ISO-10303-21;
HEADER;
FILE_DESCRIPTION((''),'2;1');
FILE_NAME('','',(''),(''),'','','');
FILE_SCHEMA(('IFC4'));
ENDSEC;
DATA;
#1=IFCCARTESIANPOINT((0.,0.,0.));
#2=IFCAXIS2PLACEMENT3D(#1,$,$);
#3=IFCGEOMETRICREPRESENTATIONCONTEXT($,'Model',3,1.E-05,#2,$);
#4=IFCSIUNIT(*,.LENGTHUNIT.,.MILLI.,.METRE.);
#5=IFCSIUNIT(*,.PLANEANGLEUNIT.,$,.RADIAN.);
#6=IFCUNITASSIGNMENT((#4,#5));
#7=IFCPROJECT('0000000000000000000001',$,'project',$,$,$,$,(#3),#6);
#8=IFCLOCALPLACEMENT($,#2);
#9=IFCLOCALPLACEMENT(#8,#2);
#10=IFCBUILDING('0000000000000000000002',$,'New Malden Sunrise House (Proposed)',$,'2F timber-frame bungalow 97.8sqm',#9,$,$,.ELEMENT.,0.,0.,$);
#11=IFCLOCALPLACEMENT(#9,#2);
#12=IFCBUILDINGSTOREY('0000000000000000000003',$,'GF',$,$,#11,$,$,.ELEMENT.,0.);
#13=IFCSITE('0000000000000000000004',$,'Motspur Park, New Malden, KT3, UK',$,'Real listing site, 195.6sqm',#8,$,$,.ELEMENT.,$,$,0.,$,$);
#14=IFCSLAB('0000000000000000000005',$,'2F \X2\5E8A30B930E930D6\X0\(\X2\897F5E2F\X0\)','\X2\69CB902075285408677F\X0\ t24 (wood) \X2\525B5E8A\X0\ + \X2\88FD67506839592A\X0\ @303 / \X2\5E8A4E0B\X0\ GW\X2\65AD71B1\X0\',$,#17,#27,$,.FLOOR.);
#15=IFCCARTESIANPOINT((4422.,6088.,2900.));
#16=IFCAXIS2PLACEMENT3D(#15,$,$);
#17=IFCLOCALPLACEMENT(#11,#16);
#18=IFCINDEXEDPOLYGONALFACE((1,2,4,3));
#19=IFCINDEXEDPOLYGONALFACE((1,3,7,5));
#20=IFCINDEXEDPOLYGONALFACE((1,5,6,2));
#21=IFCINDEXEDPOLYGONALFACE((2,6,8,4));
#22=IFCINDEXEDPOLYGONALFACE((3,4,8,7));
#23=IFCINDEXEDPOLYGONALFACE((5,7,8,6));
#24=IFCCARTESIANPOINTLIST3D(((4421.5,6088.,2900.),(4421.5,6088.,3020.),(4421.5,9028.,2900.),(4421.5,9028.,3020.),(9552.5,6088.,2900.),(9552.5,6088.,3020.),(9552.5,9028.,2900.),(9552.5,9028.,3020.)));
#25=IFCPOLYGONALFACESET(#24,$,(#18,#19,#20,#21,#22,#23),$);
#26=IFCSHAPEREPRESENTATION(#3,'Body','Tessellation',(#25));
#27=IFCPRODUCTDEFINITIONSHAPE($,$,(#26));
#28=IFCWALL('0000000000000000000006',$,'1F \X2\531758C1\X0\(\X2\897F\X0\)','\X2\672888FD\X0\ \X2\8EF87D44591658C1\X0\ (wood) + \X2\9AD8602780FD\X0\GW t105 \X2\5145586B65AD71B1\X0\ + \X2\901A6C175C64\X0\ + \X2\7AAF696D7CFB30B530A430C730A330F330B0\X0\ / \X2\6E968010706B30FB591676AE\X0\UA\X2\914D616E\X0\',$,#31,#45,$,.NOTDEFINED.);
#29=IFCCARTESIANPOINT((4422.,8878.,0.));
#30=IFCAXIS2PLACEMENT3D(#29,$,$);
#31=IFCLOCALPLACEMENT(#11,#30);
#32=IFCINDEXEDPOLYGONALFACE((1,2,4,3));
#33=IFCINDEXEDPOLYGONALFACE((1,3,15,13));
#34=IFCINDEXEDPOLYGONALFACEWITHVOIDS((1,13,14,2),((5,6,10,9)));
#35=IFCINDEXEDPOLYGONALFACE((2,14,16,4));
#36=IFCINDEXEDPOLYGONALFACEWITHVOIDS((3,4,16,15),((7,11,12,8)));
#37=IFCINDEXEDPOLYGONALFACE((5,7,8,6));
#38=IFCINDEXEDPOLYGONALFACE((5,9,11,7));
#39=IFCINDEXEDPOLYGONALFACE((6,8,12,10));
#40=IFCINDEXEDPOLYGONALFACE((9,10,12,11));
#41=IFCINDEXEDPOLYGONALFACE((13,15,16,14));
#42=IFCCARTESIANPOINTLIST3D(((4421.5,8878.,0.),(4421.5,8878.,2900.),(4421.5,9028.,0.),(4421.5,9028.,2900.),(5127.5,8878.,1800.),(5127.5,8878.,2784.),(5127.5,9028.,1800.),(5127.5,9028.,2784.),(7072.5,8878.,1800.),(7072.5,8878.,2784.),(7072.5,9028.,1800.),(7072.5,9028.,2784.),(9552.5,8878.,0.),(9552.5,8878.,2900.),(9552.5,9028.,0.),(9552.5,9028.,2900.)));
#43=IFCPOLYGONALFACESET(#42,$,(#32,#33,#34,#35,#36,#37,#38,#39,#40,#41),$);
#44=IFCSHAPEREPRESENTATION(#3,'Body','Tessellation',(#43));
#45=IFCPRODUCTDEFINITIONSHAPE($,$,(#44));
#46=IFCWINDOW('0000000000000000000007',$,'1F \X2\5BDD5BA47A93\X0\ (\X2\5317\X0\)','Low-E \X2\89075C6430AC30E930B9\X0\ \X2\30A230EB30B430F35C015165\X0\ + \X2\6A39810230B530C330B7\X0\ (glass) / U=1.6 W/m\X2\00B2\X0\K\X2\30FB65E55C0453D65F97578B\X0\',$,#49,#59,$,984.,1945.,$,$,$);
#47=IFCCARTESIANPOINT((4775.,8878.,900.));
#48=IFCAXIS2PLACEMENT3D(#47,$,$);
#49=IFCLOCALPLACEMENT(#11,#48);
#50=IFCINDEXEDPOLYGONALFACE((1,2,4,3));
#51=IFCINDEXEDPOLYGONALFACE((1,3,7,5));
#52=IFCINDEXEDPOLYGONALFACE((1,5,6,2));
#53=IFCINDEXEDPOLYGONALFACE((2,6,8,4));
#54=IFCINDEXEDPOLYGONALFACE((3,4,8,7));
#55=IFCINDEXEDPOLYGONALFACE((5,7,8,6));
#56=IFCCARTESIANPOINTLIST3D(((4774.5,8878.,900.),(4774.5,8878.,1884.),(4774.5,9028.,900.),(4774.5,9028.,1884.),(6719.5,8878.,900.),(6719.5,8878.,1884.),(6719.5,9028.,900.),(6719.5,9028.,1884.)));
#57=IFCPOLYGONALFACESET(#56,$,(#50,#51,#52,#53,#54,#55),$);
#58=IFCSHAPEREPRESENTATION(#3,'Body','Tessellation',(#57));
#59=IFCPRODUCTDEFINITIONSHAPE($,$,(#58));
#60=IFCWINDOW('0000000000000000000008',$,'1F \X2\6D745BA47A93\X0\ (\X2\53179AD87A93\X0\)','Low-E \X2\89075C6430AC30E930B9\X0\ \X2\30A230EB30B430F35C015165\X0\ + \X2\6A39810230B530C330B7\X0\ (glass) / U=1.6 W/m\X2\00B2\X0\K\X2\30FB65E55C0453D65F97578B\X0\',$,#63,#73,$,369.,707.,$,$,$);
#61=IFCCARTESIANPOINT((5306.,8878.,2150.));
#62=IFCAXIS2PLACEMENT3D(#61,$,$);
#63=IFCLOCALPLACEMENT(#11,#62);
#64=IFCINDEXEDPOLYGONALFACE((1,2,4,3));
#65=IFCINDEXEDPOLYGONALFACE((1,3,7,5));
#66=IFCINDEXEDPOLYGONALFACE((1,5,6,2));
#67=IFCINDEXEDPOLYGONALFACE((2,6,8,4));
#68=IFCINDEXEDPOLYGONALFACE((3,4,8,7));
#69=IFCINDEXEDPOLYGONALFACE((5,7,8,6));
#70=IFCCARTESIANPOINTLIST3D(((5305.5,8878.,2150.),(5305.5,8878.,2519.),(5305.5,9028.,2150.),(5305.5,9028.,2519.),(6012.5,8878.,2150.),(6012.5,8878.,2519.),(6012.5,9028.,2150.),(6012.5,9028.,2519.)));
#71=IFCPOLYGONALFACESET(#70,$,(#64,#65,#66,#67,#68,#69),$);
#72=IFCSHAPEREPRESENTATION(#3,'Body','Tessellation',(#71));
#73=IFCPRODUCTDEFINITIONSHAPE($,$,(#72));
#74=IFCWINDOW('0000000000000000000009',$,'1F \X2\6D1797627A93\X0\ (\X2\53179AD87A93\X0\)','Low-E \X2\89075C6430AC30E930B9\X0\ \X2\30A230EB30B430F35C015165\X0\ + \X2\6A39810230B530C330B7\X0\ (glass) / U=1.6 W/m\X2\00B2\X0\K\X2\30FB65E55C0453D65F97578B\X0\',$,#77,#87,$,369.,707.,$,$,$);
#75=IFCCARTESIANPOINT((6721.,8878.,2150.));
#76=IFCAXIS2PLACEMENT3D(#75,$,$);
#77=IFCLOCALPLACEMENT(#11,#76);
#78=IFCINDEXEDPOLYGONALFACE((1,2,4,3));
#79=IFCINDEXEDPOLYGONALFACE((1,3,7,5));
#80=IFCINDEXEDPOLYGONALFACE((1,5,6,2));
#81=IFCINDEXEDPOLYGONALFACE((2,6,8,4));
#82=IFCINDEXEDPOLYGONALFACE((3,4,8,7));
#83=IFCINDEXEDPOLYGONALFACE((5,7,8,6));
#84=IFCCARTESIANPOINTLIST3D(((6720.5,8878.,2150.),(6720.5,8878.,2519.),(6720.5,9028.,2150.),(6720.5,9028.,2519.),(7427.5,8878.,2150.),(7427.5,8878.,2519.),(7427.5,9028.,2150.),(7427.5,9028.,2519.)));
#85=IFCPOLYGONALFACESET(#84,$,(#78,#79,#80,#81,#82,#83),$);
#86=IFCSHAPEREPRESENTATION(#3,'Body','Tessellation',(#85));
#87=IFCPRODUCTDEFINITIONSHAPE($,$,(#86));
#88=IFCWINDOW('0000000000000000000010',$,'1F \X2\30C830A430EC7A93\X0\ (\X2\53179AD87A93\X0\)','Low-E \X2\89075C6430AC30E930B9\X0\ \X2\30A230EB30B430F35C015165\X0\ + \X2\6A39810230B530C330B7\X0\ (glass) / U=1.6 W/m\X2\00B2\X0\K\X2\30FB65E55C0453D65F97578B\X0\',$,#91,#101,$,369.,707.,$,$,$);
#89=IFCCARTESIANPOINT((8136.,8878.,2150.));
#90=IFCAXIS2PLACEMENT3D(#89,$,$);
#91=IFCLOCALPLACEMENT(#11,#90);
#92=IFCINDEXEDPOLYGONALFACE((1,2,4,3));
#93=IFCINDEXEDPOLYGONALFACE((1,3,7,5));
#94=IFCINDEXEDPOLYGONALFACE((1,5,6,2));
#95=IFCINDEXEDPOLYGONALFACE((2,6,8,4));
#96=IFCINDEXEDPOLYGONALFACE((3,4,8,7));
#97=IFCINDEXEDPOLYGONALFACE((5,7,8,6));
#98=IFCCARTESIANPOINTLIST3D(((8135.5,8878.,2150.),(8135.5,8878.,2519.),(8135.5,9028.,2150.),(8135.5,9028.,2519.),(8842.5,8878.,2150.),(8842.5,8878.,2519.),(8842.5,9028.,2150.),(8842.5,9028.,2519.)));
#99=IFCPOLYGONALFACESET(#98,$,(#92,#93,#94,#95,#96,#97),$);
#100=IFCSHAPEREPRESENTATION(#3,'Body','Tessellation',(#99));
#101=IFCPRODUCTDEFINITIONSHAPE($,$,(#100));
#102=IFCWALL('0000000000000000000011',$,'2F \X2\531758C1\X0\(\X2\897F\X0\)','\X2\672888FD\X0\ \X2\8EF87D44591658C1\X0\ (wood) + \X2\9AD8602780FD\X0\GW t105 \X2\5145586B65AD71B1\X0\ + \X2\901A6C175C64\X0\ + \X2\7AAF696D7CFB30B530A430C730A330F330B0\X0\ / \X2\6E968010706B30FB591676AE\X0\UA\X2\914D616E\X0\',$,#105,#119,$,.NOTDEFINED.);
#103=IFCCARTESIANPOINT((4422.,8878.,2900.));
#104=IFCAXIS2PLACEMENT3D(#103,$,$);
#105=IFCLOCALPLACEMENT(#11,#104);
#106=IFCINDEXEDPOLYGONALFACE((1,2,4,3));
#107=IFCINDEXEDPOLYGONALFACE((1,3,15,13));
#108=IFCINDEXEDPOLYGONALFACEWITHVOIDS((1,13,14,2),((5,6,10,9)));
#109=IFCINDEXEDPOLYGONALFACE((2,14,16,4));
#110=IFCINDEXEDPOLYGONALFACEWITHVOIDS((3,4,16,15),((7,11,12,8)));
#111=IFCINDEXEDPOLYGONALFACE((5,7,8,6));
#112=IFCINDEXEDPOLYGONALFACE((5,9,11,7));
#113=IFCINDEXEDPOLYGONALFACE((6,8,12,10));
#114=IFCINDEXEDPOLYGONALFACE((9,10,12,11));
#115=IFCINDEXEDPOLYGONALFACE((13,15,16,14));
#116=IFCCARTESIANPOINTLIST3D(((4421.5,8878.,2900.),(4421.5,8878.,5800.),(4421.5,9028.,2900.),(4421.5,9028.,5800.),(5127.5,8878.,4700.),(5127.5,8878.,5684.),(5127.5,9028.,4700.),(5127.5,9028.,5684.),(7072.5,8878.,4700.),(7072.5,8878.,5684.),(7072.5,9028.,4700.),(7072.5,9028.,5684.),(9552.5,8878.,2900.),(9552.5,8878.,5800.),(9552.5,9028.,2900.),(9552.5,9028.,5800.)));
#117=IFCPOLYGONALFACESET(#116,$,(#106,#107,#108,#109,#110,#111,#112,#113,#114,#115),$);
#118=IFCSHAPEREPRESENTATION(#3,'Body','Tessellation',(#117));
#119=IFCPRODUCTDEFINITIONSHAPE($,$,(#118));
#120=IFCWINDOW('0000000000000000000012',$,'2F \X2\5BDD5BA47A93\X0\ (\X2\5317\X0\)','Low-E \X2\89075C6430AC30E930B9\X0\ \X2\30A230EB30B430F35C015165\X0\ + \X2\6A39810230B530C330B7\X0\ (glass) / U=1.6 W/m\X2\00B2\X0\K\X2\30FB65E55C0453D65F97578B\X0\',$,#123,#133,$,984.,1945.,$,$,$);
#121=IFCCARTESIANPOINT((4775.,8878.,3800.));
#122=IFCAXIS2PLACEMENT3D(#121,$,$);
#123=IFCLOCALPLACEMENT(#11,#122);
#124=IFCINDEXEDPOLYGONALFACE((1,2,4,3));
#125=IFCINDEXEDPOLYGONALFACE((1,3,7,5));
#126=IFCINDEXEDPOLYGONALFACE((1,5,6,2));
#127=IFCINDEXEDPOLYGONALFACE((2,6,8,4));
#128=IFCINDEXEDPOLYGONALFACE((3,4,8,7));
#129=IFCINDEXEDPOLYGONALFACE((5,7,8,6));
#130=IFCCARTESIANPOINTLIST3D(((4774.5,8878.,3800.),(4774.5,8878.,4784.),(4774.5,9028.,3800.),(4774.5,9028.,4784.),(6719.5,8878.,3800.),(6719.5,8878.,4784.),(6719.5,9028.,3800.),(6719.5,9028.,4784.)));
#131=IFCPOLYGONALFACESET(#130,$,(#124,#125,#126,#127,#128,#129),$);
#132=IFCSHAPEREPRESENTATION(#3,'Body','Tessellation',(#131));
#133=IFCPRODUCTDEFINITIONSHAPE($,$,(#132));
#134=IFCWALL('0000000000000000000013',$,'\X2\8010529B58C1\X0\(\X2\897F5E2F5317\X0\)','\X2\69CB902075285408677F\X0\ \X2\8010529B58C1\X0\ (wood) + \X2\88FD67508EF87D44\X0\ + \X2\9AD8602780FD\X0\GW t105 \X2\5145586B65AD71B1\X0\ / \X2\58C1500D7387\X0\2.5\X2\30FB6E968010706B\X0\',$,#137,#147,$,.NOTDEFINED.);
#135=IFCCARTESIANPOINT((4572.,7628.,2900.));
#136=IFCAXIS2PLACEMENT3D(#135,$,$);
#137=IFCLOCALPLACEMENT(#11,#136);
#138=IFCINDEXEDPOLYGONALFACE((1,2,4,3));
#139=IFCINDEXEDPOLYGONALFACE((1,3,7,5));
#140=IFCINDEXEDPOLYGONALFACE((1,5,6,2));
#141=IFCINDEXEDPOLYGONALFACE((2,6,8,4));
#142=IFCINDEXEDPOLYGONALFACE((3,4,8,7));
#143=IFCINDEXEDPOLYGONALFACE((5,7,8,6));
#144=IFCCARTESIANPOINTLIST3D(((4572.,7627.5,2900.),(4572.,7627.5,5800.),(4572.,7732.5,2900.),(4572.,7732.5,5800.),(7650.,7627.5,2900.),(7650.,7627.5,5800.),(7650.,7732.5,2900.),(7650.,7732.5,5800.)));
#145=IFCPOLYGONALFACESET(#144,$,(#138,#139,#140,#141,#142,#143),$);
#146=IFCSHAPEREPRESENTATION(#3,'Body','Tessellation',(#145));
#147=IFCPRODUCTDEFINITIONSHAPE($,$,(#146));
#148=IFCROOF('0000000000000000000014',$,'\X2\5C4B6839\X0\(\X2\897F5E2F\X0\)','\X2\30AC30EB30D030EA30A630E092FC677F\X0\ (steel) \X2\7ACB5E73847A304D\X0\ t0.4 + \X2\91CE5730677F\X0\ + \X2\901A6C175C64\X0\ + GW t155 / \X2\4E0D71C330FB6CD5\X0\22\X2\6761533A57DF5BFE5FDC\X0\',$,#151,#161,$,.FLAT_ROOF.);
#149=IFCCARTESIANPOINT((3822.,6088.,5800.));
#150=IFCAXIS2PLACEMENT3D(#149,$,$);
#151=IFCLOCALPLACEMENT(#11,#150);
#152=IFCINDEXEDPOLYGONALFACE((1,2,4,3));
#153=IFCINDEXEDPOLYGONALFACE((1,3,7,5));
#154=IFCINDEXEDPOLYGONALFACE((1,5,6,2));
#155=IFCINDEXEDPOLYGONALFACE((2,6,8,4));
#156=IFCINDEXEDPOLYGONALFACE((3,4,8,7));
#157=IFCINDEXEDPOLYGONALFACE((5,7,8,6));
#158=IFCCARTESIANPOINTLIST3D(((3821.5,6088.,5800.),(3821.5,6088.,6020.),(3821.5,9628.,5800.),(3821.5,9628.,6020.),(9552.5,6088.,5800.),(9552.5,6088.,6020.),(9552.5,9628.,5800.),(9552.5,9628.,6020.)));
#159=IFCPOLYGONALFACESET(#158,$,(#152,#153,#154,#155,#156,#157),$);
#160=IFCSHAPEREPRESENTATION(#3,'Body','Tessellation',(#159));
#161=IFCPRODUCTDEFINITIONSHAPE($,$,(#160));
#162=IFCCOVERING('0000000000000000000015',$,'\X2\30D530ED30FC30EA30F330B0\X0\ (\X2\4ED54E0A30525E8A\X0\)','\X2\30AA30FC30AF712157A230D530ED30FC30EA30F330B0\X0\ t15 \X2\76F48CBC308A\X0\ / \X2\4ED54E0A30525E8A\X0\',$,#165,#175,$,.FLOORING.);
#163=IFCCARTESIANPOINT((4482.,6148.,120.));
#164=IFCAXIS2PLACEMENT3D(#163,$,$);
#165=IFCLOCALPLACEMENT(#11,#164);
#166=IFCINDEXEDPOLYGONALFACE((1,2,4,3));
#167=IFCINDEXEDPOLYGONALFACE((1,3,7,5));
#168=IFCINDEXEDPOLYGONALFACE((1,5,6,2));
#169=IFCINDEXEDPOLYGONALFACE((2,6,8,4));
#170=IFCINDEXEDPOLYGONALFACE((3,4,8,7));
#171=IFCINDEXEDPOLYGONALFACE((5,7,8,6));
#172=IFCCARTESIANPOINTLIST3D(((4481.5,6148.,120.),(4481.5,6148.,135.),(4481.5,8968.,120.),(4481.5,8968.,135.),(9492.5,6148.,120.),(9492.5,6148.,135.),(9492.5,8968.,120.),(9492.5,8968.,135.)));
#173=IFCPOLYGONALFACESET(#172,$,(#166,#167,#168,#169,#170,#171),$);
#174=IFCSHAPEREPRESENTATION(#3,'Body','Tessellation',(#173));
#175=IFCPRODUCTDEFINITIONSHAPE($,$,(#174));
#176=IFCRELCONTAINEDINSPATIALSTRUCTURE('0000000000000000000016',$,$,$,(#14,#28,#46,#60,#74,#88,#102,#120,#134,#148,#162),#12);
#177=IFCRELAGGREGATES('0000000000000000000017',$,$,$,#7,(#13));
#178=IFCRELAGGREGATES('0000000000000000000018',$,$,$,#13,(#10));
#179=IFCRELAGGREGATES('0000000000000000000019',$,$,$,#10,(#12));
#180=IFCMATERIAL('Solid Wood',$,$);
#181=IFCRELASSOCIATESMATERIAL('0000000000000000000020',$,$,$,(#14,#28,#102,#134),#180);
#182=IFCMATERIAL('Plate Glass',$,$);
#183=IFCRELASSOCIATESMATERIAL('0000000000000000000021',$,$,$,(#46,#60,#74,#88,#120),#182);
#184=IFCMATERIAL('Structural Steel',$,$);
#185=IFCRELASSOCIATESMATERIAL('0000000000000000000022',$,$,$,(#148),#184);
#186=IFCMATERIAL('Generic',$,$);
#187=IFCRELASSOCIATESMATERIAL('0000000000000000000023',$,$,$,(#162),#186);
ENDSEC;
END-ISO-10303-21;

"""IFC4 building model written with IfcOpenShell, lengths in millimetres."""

from ifc_helpers import new_model, si_unit, frame, frame_2d, origin, place, context, project, spatial, rectangle, extrude, material, element, fill, save


model = new_model("IFC4")

# Units and contexts
model_context = context("Model", 3, precision=1e-05, world=origin())
ifc_project = project(units=[si_unit("LENGTHUNIT", "METRE", prefix="MILLI"), si_unit("PLANEANGLEUNIT", "RADIAN")], contexts=[model_context])

# Site, building, storey
site_placement = place(None, origin())
site = spatial("IfcSite", under=ifc_project, at=site_placement, Name="Motspur Park, New Malden, KT3, UK", ObjectType="Real listing site, 195.6sqm", CompositionType="ELEMENT", RefElevation=0.0)
building_placement = place(site_placement, origin())
building = spatial("IfcBuilding", under=site, at=building_placement, Name="New Malden Sunrise House (Proposed)", ObjectType="2F timber-frame bungalow 97.8sqm", CompositionType="ELEMENT", ElevationOfRefHeight=0.0, ElevationOfTerrain=0.0)
storey_placement = place(building_placement, origin())
storey = spatial("IfcBuildingStorey", under=building, at=storey_placement, Name="GF", CompositionType="ELEMENT", Elevation=0.0)

# Slab
ifc_material_1 = material(Name="Solid Wood")
slab_1_placement = place(storey_placement, frame((4422.0, 6088.0, 2900.0)))
element("IfcSlab", 1, at=slab_1_placement, inside=storey, material=ifc_material_1, Name="2F 床スラブ(西帯)", Description="構造用合板 t24 (wood) 剛床 + 製材根太 @303 / 床下 GW断熱", PredefinedType="FLOOR", context=model_context, shape_type="SweptSolid", body=[
    extrude(rectangle(XDim=5131.0, YDim=2940.0, at=frame_2d((2565.0, 1470.0))), frame((4422.0, 6088.0, 2900.0)), (0.0, 0.0, 1.0), 120.0),
])

# Wall, openings, windows
wall_1_placement = place(storey_placement, frame((4422.0, 8878.0, 0.0)))
wall_1 = element("IfcWall", 2, at=wall_1_placement, inside=storey, material=ifc_material_1, Name="1F 北壁(西)", Description="木製 軸組外壁 (wood) + 高性能GW t105 充填断熱 + 通気層 + 窯業系サイディング / 準耐火・外皮UA配慮", PredefinedType="NOTDEFINED", context=model_context, shape_type="SweptSolid", body=[
    extrude(rectangle(XDim=5131.0, YDim=150.0, at=frame_2d((2565.0, 75.0))), frame((4422.0, 8878.0, 0.0)), (0.0, 0.0, 1.0), 2900.0),
])
opening_1_placement = place(storey_placement, frame((4775.0, 8878.0, 900.0)))
opening_1 = element("IfcOpeningElement", 3, at=opening_1_placement, cuts=wall_1, PredefinedType="NOTDEFINED", context=model_context, shape_type="SweptSolid", body=[
    extrude(rectangle(XDim=1945.0, YDim=150.0, at=frame_2d((972.0, 75.0))), frame((4775.0, 8878.0, 900.0)), (0.0, 0.0, 1.0), 984.0),
])
opening_2_placement = place(storey_placement, frame((5306.0, 8878.0, 2150.0)))
opening_2 = element("IfcOpeningElement", 4, at=opening_2_placement, cuts=wall_1, PredefinedType="NOTDEFINED", context=model_context, shape_type="SweptSolid", body=[
    extrude(rectangle(XDim=707.0, YDim=150.0, at=frame_2d((353.0, 75.0))), frame((5306.0, 8878.0, 2150.0)), (0.0, 0.0, 1.0), 369.0),
])
opening_3_placement = place(storey_placement, frame((6721.0, 8878.0, 2150.0)))
opening_3 = element("IfcOpeningElement", 5, at=opening_3_placement, cuts=wall_1, PredefinedType="NOTDEFINED", context=model_context, shape_type="SweptSolid", body=[
    extrude(rectangle(XDim=707.0, YDim=150.0, at=frame_2d((353.0, 75.0))), frame((6721.0, 8878.0, 2150.0)), (0.0, 0.0, 1.0), 369.0),
])
opening_4_placement = place(storey_placement, frame((8136.0, 8878.0, 2150.0)))
opening_4 = element("IfcOpeningElement", 6, at=opening_4_placement, cuts=wall_1, PredefinedType="NOTDEFINED", context=model_context, shape_type="SweptSolid", body=[
    extrude(rectangle(XDim=707.0, YDim=150.0, at=frame_2d((353.0, 75.0))), frame((8136.0, 8878.0, 2150.0)), (0.0, 0.0, 1.0), 369.0),
])
ifc_material_2 = material(Name="Plate Glass")
window_1_placement = place(storey_placement, frame((4775.0, 8878.0, 900.0)))
window_1 = element("IfcWindow", 7, at=window_1_placement, inside=storey, material=ifc_material_2, Name="1F 寝室窓 (北)", Description="Low-E 複層ガラス アルゴン封入 + 樹脂サッシ (glass) / U=1.6 W/m²K・日射取得型", OverallHeight=984.0, OverallWidth=1945.0, context=model_context, shape_type="SweptSolid", body=[
    extrude(rectangle(XDim=1945.0, YDim=150.0, at=frame_2d((972.0, 75.0))), frame((4775.0, 8878.0, 900.0)), (0.0, 0.0, 1.0), 984.0),
])
fill(opening_1, window_1)
window_2_placement = place(storey_placement, frame((5306.0, 8878.0, 2150.0)))
window_2 = element("IfcWindow", 8, at=window_2_placement, inside=storey, material=ifc_material_2, Name="1F 浴室窓 (北高窓)", Description="Low-E 複層ガラス アルゴン封入 + 樹脂サッシ (glass) / U=1.6 W/m²K・日射取得型", OverallHeight=369.0, OverallWidth=707.0, context=model_context, shape_type="SweptSolid", body=[
    extrude(rectangle(XDim=707.0, YDim=150.0, at=frame_2d((353.0, 75.0))), frame((5306.0, 8878.0, 2150.0)), (0.0, 0.0, 1.0), 369.0),
])
fill(opening_2, window_2)
window_3_placement = place(storey_placement, frame((6721.0, 8878.0, 2150.0)))
window_3 = element("IfcWindow", 9, at=window_3_placement, inside=storey, material=ifc_material_2, Name="1F 洗面窓 (北高窓)", Description="Low-E 複層ガラス アルゴン封入 + 樹脂サッシ (glass) / U=1.6 W/m²K・日射取得型", OverallHeight=369.0, OverallWidth=707.0, context=model_context, shape_type="SweptSolid", body=[
    extrude(rectangle(XDim=707.0, YDim=150.0, at=frame_2d((353.0, 75.0))), frame((6721.0, 8878.0, 2150.0)), (0.0, 0.0, 1.0), 369.0),
])
fill(opening_3, window_3)
window_4_placement = place(storey_placement, frame((8136.0, 8878.0, 2150.0)))
window_4 = element("IfcWindow", 10, at=window_4_placement, inside=storey, material=ifc_material_2, Name="1F トイレ窓 (北高窓)", Description="Low-E 複層ガラス アルゴン封入 + 樹脂サッシ (glass) / U=1.6 W/m²K・日射取得型", OverallHeight=369.0, OverallWidth=707.0, context=model_context, shape_type="SweptSolid", body=[
    extrude(rectangle(XDim=707.0, YDim=150.0, at=frame_2d((353.0, 75.0))), frame((8136.0, 8878.0, 2150.0)), (0.0, 0.0, 1.0), 369.0),
])
fill(opening_4, window_4)

# Wall, opening, window
wall_2_placement = place(storey_placement, frame((4422.0, 8878.0, 2900.0)))
wall_2 = element("IfcWall", 11, at=wall_2_placement, inside=storey, material=ifc_material_1, Name="2F 北壁(西)", Description="木製 軸組外壁 (wood) + 高性能GW t105 充填断熱 + 通気層 + 窯業系サイディング / 準耐火・外皮UA配慮", PredefinedType="NOTDEFINED", context=model_context, shape_type="SweptSolid", body=[
    extrude(rectangle(XDim=5131.0, YDim=150.0, at=frame_2d((2565.0, 75.0))), frame((4422.0, 8878.0, 2900.0)), (0.0, 0.0, 1.0), 2900.0),
])
opening_5_placement = place(storey_placement, frame((4775.0, 8878.0, 3800.0)))
opening_5 = element("IfcOpeningElement", 12, at=opening_5_placement, cuts=wall_2, PredefinedType="NOTDEFINED", context=model_context, shape_type="SweptSolid", body=[
    extrude(rectangle(XDim=1945.0, YDim=150.0, at=frame_2d((972.0, 75.0))), frame((4775.0, 8878.0, 3800.0)), (0.0, 0.0, 1.0), 984.0),
])
window_5_placement = place(storey_placement, frame((4775.0, 8878.0, 3800.0)))
window_5 = element("IfcWindow", 13, at=window_5_placement, inside=storey, material=ifc_material_2, Name="2F 寝室窓 (北)", Description="Low-E 複層ガラス アルゴン封入 + 樹脂サッシ (glass) / U=1.6 W/m²K・日射取得型", OverallHeight=984.0, OverallWidth=1945.0, context=model_context, shape_type="SweptSolid", body=[
    extrude(rectangle(XDim=1945.0, YDim=150.0, at=frame_2d((972.0, 75.0))), frame((4775.0, 8878.0, 3800.0)), (0.0, 0.0, 1.0), 984.0),
])
fill(opening_5, window_5)

# Wall
wall_3_placement = place(storey_placement, frame((4572.0, 7628.0, 2900.0)))
element("IfcWall", 14, at=wall_3_placement, inside=storey, material=ifc_material_1, Name="耐力壁(西帯北)", Description="構造用合板 耐力壁 (wood) + 製材軸組 + 高性能GW t105 充填断熱 / 壁倍率2.5・準耐火", PredefinedType="NOTDEFINED", context=model_context, shape_type="SweptSolid", body=[
    extrude(rectangle(XDim=3078.0, YDim=105.0, at=frame_2d((1539.0, 52.0))), frame((4572.0, 7628.0, 2900.0)), (0.0, 0.0, 1.0), 2900.0),
])

# Roof
ifc_material_3 = material(Name="Structural Steel")
for number, where, name in (
    (15, (3822.0, 6088.0, 5800.0), "屋根(西帯)"),
):
    element("IfcRoof", number, at=place(storey_placement, frame(where)), inside=storey, material=ifc_material_3, Name=name, Description="ガルバリウム鋼板 (steel) 立平葺き t0.4 + 野地板 + 通気層 + GW t155 / 不燃・法22条区域対応", PredefinedType="FLAT_ROOF", context=model_context, shape_type="SweptSolid", body=[
        extrude(rectangle(XDim=5731.0, YDim=3540.0, at=frame_2d((2865.0, 1770.0))), frame((3822.0, 6088.0, 5800.0)), (0.0, 0.0, 1.0), 220.0),
    ])

# Covering
ifc_material_4 = material(Name="Generic")
covering_1_placement = place(storey_placement, frame((4482.0, 6148.0, 120.0)))
element("IfcCovering", 16, at=covering_1_placement, inside=storey, material=ifc_material_4, Name="フローリング (仕上げ床)", Description="オーク無垢フローリング t15 直貼り / 仕上げ床", PredefinedType="FLOORING", context=model_context, shape_type="SweptSolid", body=[
    extrude(rectangle(XDim=5011.0, YDim=2820.0, at=frame_2d((2505.0, 1410.0))), frame((4482.0, 6148.0, 120.0)), (0.0, 0.0, 1.0), 15.0),
])

save(model, "model.ifc")
